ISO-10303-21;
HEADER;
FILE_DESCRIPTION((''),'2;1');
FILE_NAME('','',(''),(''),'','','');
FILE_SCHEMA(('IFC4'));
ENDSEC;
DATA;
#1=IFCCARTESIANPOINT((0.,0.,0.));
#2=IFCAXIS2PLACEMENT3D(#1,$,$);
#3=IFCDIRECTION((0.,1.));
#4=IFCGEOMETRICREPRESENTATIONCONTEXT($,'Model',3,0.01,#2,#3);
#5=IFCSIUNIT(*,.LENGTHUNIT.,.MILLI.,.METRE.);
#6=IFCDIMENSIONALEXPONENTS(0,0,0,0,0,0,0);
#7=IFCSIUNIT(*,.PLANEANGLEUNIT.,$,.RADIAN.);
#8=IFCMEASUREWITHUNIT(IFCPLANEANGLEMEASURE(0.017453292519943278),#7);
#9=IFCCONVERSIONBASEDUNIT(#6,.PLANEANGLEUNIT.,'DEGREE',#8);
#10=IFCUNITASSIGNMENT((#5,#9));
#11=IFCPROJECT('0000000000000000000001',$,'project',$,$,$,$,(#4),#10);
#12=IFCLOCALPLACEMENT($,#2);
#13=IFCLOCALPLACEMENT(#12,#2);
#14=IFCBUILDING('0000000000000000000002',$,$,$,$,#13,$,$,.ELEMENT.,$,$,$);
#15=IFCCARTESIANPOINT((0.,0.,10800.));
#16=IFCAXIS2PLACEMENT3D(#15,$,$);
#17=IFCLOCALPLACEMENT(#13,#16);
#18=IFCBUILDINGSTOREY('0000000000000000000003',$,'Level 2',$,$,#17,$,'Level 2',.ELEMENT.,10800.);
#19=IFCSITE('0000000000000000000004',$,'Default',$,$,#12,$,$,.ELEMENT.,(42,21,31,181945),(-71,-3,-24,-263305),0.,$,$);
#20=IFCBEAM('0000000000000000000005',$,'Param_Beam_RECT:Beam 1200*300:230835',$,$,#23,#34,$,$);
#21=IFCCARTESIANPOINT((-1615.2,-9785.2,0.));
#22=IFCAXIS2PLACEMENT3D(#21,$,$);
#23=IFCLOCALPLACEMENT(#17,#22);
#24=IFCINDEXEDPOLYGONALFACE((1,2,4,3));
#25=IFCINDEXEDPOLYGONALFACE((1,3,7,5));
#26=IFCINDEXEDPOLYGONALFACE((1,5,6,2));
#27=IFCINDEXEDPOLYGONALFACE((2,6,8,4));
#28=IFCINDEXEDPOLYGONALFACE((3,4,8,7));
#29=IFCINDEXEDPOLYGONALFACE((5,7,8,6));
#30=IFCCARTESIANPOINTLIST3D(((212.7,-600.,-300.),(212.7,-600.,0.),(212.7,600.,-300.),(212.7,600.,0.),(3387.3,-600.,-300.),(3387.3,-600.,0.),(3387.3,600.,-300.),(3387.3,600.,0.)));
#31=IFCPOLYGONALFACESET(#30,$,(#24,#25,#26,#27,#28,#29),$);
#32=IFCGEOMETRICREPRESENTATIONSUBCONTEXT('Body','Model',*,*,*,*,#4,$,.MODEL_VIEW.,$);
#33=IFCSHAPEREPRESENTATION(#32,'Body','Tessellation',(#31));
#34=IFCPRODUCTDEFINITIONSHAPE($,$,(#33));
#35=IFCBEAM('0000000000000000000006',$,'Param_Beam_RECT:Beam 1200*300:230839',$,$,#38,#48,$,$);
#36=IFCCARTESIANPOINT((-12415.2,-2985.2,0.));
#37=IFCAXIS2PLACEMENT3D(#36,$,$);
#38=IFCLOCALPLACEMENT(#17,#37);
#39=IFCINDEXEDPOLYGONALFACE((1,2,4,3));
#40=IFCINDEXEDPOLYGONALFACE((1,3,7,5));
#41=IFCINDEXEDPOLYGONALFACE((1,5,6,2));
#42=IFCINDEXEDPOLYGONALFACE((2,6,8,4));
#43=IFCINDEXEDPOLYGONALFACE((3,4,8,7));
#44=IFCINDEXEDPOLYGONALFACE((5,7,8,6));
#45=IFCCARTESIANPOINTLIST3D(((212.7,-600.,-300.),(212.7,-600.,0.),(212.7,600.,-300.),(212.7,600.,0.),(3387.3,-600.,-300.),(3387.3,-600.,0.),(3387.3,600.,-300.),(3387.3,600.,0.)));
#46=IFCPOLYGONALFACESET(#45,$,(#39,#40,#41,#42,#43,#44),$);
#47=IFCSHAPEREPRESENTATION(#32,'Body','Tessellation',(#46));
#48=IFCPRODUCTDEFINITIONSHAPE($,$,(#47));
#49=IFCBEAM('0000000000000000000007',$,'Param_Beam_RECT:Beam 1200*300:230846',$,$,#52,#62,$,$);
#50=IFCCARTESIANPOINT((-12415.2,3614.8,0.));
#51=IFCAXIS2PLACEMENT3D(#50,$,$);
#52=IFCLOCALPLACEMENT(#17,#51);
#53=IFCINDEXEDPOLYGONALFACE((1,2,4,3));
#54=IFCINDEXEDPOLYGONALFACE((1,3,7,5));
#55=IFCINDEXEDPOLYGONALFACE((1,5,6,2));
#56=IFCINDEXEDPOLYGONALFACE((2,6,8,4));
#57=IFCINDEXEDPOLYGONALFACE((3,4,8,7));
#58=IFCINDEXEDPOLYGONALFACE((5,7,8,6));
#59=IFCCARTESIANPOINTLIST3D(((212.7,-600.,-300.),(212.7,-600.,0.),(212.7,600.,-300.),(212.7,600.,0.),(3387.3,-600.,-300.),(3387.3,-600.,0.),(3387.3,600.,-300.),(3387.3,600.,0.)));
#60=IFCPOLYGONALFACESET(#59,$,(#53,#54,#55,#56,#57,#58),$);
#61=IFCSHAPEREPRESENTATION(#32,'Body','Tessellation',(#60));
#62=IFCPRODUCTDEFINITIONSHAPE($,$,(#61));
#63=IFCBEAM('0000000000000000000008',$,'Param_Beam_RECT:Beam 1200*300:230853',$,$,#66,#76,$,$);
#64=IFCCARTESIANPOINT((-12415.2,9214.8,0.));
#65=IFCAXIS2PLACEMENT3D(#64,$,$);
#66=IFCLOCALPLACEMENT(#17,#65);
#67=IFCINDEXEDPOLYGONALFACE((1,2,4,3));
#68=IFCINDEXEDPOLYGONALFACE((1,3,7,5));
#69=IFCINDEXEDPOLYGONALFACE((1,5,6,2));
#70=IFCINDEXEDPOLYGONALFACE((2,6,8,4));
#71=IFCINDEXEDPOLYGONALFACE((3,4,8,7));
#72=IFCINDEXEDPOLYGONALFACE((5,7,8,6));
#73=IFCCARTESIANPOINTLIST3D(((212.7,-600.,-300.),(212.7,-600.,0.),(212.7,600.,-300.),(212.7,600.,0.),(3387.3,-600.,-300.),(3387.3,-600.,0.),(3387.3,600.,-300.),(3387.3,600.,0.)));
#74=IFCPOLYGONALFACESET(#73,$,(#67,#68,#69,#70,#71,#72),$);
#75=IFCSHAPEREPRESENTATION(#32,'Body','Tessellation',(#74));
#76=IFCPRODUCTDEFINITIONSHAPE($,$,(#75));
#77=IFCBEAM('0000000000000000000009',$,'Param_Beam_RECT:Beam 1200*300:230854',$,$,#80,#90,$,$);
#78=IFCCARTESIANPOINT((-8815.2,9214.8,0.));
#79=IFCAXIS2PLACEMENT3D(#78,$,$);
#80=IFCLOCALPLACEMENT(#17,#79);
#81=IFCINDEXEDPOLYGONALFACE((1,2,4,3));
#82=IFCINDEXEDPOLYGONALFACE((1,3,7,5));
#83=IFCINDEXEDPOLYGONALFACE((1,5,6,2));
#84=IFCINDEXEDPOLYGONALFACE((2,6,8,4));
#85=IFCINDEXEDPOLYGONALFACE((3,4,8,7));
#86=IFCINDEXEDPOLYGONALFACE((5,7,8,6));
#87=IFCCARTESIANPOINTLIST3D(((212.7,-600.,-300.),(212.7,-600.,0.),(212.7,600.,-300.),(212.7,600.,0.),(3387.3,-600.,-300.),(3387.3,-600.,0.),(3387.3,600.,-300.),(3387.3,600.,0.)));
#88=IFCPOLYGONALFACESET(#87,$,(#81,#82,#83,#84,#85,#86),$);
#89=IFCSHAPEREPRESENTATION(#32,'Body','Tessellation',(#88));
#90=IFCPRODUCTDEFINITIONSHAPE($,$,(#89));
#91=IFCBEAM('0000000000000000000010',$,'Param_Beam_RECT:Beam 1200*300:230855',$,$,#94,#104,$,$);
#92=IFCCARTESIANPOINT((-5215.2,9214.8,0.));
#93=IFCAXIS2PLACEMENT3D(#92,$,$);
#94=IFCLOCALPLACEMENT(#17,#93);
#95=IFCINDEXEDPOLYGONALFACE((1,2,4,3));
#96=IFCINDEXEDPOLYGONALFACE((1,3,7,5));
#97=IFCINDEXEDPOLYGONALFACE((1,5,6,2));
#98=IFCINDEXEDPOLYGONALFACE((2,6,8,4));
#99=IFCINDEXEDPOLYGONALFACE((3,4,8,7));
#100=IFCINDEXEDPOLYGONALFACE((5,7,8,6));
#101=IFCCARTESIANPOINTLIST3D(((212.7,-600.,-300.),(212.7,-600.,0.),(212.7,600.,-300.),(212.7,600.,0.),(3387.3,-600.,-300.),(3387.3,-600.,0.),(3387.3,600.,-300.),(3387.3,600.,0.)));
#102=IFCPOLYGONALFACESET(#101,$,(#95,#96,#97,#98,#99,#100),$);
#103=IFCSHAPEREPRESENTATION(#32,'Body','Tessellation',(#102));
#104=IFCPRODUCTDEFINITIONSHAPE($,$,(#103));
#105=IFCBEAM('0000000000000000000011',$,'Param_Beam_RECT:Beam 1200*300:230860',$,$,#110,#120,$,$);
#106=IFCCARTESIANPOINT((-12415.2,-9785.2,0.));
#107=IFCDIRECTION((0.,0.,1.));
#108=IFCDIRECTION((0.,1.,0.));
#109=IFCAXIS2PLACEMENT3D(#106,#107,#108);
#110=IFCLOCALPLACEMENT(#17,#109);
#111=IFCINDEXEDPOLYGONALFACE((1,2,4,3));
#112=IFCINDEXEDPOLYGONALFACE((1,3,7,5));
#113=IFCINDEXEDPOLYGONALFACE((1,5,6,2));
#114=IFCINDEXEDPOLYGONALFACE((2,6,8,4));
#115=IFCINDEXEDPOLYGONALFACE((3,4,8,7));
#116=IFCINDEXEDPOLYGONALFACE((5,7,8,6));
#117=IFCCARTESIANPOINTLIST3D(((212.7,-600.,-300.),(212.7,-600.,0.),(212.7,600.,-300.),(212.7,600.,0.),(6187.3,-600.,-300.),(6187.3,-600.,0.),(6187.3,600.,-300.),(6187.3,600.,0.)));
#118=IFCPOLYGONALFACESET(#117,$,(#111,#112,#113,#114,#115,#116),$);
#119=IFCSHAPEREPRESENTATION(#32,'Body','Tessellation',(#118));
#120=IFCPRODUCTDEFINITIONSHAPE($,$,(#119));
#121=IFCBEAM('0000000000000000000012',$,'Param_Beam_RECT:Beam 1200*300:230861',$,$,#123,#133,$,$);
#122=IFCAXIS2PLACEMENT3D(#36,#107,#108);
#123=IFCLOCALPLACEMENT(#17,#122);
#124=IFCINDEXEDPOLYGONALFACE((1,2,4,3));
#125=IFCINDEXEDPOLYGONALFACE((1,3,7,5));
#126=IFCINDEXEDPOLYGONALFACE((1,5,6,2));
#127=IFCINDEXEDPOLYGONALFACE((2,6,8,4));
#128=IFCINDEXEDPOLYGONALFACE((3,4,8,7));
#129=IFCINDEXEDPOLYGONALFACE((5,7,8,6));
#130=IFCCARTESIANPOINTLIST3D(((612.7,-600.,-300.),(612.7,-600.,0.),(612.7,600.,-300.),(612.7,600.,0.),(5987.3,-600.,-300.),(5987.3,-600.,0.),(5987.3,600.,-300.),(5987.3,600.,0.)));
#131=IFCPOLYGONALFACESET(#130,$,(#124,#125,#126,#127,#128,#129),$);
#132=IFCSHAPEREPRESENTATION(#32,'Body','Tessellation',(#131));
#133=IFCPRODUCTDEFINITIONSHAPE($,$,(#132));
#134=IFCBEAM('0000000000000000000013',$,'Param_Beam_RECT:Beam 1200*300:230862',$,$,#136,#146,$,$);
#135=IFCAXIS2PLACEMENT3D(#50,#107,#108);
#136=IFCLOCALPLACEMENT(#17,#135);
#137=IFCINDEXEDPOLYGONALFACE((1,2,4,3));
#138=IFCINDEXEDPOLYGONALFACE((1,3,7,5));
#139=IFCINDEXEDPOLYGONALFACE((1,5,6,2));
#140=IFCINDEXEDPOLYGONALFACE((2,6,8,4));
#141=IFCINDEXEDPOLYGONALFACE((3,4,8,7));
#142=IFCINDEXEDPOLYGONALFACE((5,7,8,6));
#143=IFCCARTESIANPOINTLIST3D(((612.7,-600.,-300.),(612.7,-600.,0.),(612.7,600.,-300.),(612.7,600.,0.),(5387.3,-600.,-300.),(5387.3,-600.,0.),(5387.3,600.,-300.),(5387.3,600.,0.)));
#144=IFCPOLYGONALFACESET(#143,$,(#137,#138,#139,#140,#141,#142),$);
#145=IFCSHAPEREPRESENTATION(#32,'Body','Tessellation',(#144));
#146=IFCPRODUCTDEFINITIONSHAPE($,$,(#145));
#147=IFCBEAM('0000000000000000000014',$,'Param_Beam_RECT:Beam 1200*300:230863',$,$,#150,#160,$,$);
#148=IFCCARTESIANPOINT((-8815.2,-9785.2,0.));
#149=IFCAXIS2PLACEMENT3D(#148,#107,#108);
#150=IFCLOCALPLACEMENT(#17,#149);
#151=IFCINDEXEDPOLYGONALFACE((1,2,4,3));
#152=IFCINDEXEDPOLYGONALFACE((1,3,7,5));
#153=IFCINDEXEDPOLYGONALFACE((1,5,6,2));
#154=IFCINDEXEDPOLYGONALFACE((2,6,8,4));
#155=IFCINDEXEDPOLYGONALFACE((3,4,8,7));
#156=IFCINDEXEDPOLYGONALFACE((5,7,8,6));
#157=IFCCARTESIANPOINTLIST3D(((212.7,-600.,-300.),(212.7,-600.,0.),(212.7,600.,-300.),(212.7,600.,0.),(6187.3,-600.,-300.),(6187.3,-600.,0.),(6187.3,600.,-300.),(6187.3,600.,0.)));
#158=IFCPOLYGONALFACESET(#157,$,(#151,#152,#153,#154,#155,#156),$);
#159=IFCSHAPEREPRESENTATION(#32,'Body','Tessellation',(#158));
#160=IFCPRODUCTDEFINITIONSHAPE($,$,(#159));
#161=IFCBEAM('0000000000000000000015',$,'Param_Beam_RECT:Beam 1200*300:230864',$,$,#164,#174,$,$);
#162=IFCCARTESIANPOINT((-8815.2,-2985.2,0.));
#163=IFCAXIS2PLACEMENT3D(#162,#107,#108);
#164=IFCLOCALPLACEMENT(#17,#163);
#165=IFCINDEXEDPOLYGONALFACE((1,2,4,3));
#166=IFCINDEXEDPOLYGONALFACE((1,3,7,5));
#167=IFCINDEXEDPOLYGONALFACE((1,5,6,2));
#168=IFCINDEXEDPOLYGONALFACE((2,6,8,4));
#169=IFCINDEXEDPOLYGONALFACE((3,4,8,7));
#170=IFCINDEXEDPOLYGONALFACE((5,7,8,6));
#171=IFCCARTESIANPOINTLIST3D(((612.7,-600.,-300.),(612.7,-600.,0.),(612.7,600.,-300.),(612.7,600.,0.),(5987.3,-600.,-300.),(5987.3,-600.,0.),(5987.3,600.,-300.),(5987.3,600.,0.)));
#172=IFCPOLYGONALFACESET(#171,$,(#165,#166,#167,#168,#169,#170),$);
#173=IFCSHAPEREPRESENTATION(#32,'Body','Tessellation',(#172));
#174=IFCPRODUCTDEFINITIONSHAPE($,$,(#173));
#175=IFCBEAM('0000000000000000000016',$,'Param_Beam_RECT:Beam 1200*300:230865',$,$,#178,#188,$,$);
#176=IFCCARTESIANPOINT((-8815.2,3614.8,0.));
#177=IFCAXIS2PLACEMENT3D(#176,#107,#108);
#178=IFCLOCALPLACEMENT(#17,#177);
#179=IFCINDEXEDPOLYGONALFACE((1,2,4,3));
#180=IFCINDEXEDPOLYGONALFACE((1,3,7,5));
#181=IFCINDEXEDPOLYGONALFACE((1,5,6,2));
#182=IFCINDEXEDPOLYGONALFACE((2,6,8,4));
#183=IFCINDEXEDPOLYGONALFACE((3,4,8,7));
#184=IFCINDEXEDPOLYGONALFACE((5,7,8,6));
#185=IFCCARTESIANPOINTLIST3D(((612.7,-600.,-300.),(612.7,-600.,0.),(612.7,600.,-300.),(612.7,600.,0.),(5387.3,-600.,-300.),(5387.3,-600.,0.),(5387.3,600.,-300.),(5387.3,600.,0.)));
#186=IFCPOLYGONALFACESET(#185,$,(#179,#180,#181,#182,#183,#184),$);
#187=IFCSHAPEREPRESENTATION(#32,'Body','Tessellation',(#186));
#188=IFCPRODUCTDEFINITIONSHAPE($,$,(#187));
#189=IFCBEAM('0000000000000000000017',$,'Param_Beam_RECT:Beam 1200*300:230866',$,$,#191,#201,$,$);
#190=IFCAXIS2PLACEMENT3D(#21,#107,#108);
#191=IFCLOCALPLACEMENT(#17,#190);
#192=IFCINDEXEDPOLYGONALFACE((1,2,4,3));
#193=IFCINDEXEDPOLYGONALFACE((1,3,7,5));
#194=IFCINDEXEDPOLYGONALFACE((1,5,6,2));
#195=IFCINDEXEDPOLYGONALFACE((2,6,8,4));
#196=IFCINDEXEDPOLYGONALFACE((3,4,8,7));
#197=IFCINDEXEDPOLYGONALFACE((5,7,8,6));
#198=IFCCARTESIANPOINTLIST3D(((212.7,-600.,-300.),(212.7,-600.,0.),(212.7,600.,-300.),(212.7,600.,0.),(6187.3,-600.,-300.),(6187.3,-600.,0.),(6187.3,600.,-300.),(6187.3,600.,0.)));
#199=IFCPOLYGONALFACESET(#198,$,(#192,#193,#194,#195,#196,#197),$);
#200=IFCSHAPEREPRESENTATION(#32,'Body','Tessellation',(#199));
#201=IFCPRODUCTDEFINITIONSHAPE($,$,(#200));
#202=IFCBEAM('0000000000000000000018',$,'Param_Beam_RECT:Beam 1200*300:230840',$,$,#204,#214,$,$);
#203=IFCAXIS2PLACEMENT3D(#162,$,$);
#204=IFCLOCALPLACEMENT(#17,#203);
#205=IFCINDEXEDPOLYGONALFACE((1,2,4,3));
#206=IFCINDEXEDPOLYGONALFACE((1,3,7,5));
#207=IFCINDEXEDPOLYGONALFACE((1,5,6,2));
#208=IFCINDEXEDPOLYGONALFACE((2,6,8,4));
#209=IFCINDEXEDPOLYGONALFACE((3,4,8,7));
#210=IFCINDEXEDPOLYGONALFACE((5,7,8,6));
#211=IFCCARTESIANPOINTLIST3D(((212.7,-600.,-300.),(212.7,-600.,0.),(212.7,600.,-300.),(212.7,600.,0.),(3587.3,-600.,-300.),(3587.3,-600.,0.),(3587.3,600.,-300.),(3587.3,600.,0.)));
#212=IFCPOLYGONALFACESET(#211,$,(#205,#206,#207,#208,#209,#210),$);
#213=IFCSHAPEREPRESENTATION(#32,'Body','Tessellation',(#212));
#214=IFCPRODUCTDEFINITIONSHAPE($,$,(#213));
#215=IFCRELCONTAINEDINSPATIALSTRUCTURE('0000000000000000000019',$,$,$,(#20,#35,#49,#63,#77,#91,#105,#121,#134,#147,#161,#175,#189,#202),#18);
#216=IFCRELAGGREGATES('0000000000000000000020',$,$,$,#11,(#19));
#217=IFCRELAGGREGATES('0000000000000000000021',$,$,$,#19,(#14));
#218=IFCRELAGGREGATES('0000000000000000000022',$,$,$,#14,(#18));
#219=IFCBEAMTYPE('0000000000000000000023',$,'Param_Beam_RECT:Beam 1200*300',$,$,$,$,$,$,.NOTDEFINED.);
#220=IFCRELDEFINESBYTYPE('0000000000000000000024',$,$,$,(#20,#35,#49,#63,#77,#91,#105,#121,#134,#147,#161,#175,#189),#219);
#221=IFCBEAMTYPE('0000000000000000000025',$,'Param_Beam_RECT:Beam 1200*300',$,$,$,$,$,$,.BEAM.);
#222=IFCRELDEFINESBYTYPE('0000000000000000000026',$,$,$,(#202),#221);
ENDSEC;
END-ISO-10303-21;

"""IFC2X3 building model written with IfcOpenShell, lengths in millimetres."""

from ifc_helpers import new_model, entity, si_unit, converted_unit, direction, frame, frame_2d, origin, origin_2d_with_axis, place, context, subcontext, project, spatial, rectangle, extrude, type_object, element, save


model = new_model("IFC2X3")

# Units and contexts
model_context = context("Model", 3, precision=0.01, world=origin(), true_north=direction((0.0, 1.0)))
body_context = subcontext(model_context, "Body", "Model", "MODEL_VIEW")
ifc_project = project(units=[si_unit("LENGTHUNIT", "METRE", prefix="MILLI"), converted_unit("PLANEANGLEUNIT", "DEGREE", entity("IfcPlaneAngleMeasure", 0.017453292519943278), si_unit("PLANEANGLEUNIT", "RADIAN"), dimensions=[0, 0, 0, 0, 0, 0, 0])], contexts=[model_context])

# Site, building, storey
site_placement = place(None, origin())
site = spatial("IfcSite", under=ifc_project, at=site_placement, Name="Default", CompositionType="ELEMENT", RefLatitude=(42, 21, 31, 181945), RefLongitude=(-71, -3, -24, -263305), RefElevation=0.0)
building_placement = place(site_placement, origin())
building = spatial("IfcBuilding", under=site, at=building_placement, CompositionType="ELEMENT")
storey_placement = place(building_placement, frame((0.0, 0.0, 10800.0)))
storey = spatial("IfcBuildingStorey", under=building, at=storey_placement, Name="Level 2", LongName="Level 2", CompositionType="ELEMENT", Elevation=10800.0)

# Beams
beam_type_1 = type_object("IfcBeamType", Name="Param_Beam_RECT:Beam 1200*300", PredefinedType="NOTDEFINED")
beam_1_placement = place(storey_placement, frame((-1615.2, -9785.2, 0.0)))
element("IfcBeam", 1, at=beam_1_placement, inside=storey, type_object=beam_type_1, Name="Param_Beam_RECT:Beam 1200*300:230835", context=body_context, shape_type="SweptSolid", body=[
    extrude(rectangle(XDim=300.0, YDim=1200.0, at=origin_2d_with_axis()), frame((212.7, 0.0, -150.0), z_axis=(1.0, 0.0, 0.0), x_axis=(0.0, 0.0, -1.0)), (0.0, 0.0, 1.0), 3174.6),
])
beam_2_placement = place(storey_placement, frame((-12415.2, -2985.2, 0.0)))
element("IfcBeam", 2, at=beam_2_placement, inside=storey, type_object=beam_type_1, Name="Param_Beam_RECT:Beam 1200*300:230839", context=body_context, shape_type="SweptSolid", body=[
    extrude(rectangle(XDim=300.0, YDim=1200.0, at=frame_2d((0.0, 0.0), x_axis=(1.0, 0.0))), frame((212.7, 0.0, -150.0), z_axis=(1.0, 0.0, 0.0), x_axis=(0.0, 0.0, -1.0)), (0.0, 0.0, 1.0), 3174.6),
])
beam_3_placement = place(storey_placement, frame((-12415.2, 3614.8, 0.0)))
element("IfcBeam", 3, at=beam_3_placement, inside=storey, type_object=beam_type_1, Name="Param_Beam_RECT:Beam 1200*300:230846", context=body_context, shape_type="SweptSolid", body=[
    extrude(rectangle(XDim=300.0, YDim=1200.0, at=origin_2d_with_axis()), frame((212.7, 0.0, -150.0), z_axis=(1.0, 0.0, 0.0), x_axis=(0.0, 0.0, -1.0)), (0.0, 0.0, 1.0), 3174.6),
])
beam_4_placement = place(storey_placement, frame((-12415.2, 9214.8, 0.0)))
element("IfcBeam", 4, at=beam_4_placement, inside=storey, type_object=beam_type_1, Name="Param_Beam_RECT:Beam 1200*300:230853", context=body_context, shape_type="SweptSolid", body=[
    extrude(rectangle(XDim=300.0, YDim=1200.0, at=frame_2d((0.0, 0.0), x_axis=(1.0, 0.0))), frame((212.7, 0.0, -150.0), z_axis=(1.0, 0.0, 0.0), x_axis=(0.0, 0.0, -1.0)), (0.0, 0.0, 1.0), 3174.6),
])
for number, where, name in (
    (5, (-8815.2, 9214.8, 0.0), "Param_Beam_RECT:Beam 1200*300:230854"),
    (6, (-5215.2, 9214.8, 0.0), "Param_Beam_RECT:Beam 1200*300:230855"),
):
    element("IfcBeam", number, at=place(storey_placement, frame(where)), inside=storey, type_object=beam_type_1, Name=name, context=body_context, shape_type="SweptSolid", body=[
        extrude(rectangle(XDim=300.0, YDim=1200.0, at=frame_2d((0.0, 0.0), x_axis=(1.0, 0.0))), frame((212.7, 0.0, -150.0), z_axis=(1.0, 0.0, 0.0), x_axis=(0.0, 0.0, -1.0)), (0.0, 0.0, 1.0), 3174.6),
    ])
beam_5_placement = place(storey_placement, frame((-12415.2, -9785.2, 0.0), z_axis=(0.0, 0.0, 1.0), x_axis=(0.0, 1.0, 0.0)))
element("IfcBeam", 7, at=beam_5_placement, inside=storey, type_object=beam_type_1, Name="Param_Beam_RECT:Beam 1200*300:230860", context=body_context, shape_type="SweptSolid", body=[
    extrude(rectangle(XDim=300.0, YDim=1200.0, at=origin_2d_with_axis()), frame((212.7, 0.0, -150.0), z_axis=(1.0, 0.0, 0.0), x_axis=(0.0, 0.0, -1.0)), (0.0, 0.0, 1.0), 5974.6),
])
beam_6_placement = place(storey_placement, frame((-12415.2, -2985.2, 0.0), z_axis=(0.0, 0.0, 1.0), x_axis=(0.0, 1.0, 0.0)))
element("IfcBeam", 8, at=beam_6_placement, inside=storey, type_object=beam_type_1, Name="Param_Beam_RECT:Beam 1200*300:230861", context=body_context, shape_type="SweptSolid", body=[
    extrude(rectangle(XDim=300.0, YDim=1200.0, at=frame_2d((0.0, 0.0), x_axis=(1.0, 0.0))), frame((612.7, 0.0, -150.0), z_axis=(1.0, 0.0, 0.0), x_axis=(0.0, 0.0, -1.0)), (0.0, 0.0, 1.0), 5374.6),
])
beam_7_placement = place(storey_placement, frame((-12415.2, 3614.8, 0.0), z_axis=(0.0, 0.0, 1.0), x_axis=(0.0, 1.0, 0.0)))
element("IfcBeam", 9, at=beam_7_placement, inside=storey, type_object=beam_type_1, Name="Param_Beam_RECT:Beam 1200*300:230862", context=body_context, shape_type="SweptSolid", body=[
    extrude(rectangle(XDim=300.0, YDim=1200.0, at=origin_2d_with_axis()), frame((612.7, 0.0, -150.0), z_axis=(1.0, 0.0, 0.0), x_axis=(0.0, 0.0, -1.0)), (0.0, 0.0, 1.0), 4774.6),
])
beam_8_placement = place(storey_placement, frame((-8815.2, -9785.2, 0.0), z_axis=(0.0, 0.0, 1.0), x_axis=(0.0, 1.0, 0.0)))
element("IfcBeam", 10, at=beam_8_placement, inside=storey, type_object=beam_type_1, Name="Param_Beam_RECT:Beam 1200*300:230863", context=body_context, shape_type="SweptSolid", body=[
    extrude(rectangle(XDim=300.0, YDim=1200.0, at=frame_2d((0.0, 0.0), x_axis=(1.0, 0.0))), frame((212.7, 0.0, -150.0), z_axis=(1.0, 0.0, 0.0), x_axis=(0.0, 0.0, -1.0)), (0.0, 0.0, 1.0), 5974.6),
])
beam_9_placement = place(storey_placement, frame((-8815.2, -2985.2, 0.0), z_axis=(0.0, 0.0, 1.0), x_axis=(0.0, 1.0, 0.0)))
element("IfcBeam", 11, at=beam_9_placement, inside=storey, type_object=beam_type_1, Name="Param_Beam_RECT:Beam 1200*300:230864", context=body_context, shape_type="SweptSolid", body=[
    extrude(rectangle(XDim=300.0, YDim=1200.0, at=frame_2d((0.0, 0.0), x_axis=(1.0, 0.0))), frame((612.7, 0.0, -150.0), z_axis=(1.0, 0.0, 0.0), x_axis=(0.0, 0.0, -1.0)), (0.0, 0.0, 1.0), 5374.6),
])
beam_10_placement = place(storey_placement, frame((-8815.2, 3614.8, 0.0), z_axis=(0.0, 0.0, 1.0), x_axis=(0.0, 1.0, 0.0)))
element("IfcBeam", 12, at=beam_10_placement, inside=storey, type_object=beam_type_1, Name="Param_Beam_RECT:Beam 1200*300:230865", context=body_context, shape_type="SweptSolid", body=[
    extrude(rectangle(XDim=300.0, YDim=1200.0, at=frame_2d((0.0, 0.0), x_axis=(1.0, 0.0))), frame((612.7, 0.0, -150.0), z_axis=(1.0, 0.0, 0.0), x_axis=(0.0, 0.0, -1.0)), (0.0, 0.0, 1.0), 4774.6),
])
beam_11_placement = place(storey_placement, frame((-1615.2, -9785.2, 0.0), z_axis=(0.0, 0.0, 1.0), x_axis=(0.0, 1.0, 0.0)))
element("IfcBeam", 13, at=beam_11_placement, inside=storey, type_object=beam_type_1, Name="Param_Beam_RECT:Beam 1200*300:230866", context=body_context, shape_type="SweptSolid", body=[
    extrude(rectangle(XDim=300.0, YDim=1200.0, at=frame_2d((0.0, 0.0), x_axis=(1.0, 0.0))), frame((212.7, 0.0, -150.0), z_axis=(1.0, 0.0, 0.0), x_axis=(0.0, 0.0, -1.0)), (0.0, 0.0, 1.0), 5974.6),
])
beam_type_2 = type_object("IfcBeamType", Name="Param_Beam_RECT:Beam 1200*300", PredefinedType="BEAM")
beam_12_placement = place(storey_placement, frame((-8815.2, -2985.2, 0.0)))
element("IfcBeam", 14, at=beam_12_placement, inside=storey, type_object=beam_type_2, Name="Param_Beam_RECT:Beam 1200*300:230840", context=body_context, shape_type="SweptSolid", body=[
    extrude(rectangle(XDim=300.0, YDim=1200.0, at=frame_2d((0.0, 0.0), x_axis=(1.0, 0.0))), frame((212.7, 0.0, -150.0), z_axis=(1.0, 0.0, 0.0), x_axis=(0.0, 0.0, -1.0)), (0.0, 0.0, 1.0), 3374.6),
])

save(model, "model.ifc")
